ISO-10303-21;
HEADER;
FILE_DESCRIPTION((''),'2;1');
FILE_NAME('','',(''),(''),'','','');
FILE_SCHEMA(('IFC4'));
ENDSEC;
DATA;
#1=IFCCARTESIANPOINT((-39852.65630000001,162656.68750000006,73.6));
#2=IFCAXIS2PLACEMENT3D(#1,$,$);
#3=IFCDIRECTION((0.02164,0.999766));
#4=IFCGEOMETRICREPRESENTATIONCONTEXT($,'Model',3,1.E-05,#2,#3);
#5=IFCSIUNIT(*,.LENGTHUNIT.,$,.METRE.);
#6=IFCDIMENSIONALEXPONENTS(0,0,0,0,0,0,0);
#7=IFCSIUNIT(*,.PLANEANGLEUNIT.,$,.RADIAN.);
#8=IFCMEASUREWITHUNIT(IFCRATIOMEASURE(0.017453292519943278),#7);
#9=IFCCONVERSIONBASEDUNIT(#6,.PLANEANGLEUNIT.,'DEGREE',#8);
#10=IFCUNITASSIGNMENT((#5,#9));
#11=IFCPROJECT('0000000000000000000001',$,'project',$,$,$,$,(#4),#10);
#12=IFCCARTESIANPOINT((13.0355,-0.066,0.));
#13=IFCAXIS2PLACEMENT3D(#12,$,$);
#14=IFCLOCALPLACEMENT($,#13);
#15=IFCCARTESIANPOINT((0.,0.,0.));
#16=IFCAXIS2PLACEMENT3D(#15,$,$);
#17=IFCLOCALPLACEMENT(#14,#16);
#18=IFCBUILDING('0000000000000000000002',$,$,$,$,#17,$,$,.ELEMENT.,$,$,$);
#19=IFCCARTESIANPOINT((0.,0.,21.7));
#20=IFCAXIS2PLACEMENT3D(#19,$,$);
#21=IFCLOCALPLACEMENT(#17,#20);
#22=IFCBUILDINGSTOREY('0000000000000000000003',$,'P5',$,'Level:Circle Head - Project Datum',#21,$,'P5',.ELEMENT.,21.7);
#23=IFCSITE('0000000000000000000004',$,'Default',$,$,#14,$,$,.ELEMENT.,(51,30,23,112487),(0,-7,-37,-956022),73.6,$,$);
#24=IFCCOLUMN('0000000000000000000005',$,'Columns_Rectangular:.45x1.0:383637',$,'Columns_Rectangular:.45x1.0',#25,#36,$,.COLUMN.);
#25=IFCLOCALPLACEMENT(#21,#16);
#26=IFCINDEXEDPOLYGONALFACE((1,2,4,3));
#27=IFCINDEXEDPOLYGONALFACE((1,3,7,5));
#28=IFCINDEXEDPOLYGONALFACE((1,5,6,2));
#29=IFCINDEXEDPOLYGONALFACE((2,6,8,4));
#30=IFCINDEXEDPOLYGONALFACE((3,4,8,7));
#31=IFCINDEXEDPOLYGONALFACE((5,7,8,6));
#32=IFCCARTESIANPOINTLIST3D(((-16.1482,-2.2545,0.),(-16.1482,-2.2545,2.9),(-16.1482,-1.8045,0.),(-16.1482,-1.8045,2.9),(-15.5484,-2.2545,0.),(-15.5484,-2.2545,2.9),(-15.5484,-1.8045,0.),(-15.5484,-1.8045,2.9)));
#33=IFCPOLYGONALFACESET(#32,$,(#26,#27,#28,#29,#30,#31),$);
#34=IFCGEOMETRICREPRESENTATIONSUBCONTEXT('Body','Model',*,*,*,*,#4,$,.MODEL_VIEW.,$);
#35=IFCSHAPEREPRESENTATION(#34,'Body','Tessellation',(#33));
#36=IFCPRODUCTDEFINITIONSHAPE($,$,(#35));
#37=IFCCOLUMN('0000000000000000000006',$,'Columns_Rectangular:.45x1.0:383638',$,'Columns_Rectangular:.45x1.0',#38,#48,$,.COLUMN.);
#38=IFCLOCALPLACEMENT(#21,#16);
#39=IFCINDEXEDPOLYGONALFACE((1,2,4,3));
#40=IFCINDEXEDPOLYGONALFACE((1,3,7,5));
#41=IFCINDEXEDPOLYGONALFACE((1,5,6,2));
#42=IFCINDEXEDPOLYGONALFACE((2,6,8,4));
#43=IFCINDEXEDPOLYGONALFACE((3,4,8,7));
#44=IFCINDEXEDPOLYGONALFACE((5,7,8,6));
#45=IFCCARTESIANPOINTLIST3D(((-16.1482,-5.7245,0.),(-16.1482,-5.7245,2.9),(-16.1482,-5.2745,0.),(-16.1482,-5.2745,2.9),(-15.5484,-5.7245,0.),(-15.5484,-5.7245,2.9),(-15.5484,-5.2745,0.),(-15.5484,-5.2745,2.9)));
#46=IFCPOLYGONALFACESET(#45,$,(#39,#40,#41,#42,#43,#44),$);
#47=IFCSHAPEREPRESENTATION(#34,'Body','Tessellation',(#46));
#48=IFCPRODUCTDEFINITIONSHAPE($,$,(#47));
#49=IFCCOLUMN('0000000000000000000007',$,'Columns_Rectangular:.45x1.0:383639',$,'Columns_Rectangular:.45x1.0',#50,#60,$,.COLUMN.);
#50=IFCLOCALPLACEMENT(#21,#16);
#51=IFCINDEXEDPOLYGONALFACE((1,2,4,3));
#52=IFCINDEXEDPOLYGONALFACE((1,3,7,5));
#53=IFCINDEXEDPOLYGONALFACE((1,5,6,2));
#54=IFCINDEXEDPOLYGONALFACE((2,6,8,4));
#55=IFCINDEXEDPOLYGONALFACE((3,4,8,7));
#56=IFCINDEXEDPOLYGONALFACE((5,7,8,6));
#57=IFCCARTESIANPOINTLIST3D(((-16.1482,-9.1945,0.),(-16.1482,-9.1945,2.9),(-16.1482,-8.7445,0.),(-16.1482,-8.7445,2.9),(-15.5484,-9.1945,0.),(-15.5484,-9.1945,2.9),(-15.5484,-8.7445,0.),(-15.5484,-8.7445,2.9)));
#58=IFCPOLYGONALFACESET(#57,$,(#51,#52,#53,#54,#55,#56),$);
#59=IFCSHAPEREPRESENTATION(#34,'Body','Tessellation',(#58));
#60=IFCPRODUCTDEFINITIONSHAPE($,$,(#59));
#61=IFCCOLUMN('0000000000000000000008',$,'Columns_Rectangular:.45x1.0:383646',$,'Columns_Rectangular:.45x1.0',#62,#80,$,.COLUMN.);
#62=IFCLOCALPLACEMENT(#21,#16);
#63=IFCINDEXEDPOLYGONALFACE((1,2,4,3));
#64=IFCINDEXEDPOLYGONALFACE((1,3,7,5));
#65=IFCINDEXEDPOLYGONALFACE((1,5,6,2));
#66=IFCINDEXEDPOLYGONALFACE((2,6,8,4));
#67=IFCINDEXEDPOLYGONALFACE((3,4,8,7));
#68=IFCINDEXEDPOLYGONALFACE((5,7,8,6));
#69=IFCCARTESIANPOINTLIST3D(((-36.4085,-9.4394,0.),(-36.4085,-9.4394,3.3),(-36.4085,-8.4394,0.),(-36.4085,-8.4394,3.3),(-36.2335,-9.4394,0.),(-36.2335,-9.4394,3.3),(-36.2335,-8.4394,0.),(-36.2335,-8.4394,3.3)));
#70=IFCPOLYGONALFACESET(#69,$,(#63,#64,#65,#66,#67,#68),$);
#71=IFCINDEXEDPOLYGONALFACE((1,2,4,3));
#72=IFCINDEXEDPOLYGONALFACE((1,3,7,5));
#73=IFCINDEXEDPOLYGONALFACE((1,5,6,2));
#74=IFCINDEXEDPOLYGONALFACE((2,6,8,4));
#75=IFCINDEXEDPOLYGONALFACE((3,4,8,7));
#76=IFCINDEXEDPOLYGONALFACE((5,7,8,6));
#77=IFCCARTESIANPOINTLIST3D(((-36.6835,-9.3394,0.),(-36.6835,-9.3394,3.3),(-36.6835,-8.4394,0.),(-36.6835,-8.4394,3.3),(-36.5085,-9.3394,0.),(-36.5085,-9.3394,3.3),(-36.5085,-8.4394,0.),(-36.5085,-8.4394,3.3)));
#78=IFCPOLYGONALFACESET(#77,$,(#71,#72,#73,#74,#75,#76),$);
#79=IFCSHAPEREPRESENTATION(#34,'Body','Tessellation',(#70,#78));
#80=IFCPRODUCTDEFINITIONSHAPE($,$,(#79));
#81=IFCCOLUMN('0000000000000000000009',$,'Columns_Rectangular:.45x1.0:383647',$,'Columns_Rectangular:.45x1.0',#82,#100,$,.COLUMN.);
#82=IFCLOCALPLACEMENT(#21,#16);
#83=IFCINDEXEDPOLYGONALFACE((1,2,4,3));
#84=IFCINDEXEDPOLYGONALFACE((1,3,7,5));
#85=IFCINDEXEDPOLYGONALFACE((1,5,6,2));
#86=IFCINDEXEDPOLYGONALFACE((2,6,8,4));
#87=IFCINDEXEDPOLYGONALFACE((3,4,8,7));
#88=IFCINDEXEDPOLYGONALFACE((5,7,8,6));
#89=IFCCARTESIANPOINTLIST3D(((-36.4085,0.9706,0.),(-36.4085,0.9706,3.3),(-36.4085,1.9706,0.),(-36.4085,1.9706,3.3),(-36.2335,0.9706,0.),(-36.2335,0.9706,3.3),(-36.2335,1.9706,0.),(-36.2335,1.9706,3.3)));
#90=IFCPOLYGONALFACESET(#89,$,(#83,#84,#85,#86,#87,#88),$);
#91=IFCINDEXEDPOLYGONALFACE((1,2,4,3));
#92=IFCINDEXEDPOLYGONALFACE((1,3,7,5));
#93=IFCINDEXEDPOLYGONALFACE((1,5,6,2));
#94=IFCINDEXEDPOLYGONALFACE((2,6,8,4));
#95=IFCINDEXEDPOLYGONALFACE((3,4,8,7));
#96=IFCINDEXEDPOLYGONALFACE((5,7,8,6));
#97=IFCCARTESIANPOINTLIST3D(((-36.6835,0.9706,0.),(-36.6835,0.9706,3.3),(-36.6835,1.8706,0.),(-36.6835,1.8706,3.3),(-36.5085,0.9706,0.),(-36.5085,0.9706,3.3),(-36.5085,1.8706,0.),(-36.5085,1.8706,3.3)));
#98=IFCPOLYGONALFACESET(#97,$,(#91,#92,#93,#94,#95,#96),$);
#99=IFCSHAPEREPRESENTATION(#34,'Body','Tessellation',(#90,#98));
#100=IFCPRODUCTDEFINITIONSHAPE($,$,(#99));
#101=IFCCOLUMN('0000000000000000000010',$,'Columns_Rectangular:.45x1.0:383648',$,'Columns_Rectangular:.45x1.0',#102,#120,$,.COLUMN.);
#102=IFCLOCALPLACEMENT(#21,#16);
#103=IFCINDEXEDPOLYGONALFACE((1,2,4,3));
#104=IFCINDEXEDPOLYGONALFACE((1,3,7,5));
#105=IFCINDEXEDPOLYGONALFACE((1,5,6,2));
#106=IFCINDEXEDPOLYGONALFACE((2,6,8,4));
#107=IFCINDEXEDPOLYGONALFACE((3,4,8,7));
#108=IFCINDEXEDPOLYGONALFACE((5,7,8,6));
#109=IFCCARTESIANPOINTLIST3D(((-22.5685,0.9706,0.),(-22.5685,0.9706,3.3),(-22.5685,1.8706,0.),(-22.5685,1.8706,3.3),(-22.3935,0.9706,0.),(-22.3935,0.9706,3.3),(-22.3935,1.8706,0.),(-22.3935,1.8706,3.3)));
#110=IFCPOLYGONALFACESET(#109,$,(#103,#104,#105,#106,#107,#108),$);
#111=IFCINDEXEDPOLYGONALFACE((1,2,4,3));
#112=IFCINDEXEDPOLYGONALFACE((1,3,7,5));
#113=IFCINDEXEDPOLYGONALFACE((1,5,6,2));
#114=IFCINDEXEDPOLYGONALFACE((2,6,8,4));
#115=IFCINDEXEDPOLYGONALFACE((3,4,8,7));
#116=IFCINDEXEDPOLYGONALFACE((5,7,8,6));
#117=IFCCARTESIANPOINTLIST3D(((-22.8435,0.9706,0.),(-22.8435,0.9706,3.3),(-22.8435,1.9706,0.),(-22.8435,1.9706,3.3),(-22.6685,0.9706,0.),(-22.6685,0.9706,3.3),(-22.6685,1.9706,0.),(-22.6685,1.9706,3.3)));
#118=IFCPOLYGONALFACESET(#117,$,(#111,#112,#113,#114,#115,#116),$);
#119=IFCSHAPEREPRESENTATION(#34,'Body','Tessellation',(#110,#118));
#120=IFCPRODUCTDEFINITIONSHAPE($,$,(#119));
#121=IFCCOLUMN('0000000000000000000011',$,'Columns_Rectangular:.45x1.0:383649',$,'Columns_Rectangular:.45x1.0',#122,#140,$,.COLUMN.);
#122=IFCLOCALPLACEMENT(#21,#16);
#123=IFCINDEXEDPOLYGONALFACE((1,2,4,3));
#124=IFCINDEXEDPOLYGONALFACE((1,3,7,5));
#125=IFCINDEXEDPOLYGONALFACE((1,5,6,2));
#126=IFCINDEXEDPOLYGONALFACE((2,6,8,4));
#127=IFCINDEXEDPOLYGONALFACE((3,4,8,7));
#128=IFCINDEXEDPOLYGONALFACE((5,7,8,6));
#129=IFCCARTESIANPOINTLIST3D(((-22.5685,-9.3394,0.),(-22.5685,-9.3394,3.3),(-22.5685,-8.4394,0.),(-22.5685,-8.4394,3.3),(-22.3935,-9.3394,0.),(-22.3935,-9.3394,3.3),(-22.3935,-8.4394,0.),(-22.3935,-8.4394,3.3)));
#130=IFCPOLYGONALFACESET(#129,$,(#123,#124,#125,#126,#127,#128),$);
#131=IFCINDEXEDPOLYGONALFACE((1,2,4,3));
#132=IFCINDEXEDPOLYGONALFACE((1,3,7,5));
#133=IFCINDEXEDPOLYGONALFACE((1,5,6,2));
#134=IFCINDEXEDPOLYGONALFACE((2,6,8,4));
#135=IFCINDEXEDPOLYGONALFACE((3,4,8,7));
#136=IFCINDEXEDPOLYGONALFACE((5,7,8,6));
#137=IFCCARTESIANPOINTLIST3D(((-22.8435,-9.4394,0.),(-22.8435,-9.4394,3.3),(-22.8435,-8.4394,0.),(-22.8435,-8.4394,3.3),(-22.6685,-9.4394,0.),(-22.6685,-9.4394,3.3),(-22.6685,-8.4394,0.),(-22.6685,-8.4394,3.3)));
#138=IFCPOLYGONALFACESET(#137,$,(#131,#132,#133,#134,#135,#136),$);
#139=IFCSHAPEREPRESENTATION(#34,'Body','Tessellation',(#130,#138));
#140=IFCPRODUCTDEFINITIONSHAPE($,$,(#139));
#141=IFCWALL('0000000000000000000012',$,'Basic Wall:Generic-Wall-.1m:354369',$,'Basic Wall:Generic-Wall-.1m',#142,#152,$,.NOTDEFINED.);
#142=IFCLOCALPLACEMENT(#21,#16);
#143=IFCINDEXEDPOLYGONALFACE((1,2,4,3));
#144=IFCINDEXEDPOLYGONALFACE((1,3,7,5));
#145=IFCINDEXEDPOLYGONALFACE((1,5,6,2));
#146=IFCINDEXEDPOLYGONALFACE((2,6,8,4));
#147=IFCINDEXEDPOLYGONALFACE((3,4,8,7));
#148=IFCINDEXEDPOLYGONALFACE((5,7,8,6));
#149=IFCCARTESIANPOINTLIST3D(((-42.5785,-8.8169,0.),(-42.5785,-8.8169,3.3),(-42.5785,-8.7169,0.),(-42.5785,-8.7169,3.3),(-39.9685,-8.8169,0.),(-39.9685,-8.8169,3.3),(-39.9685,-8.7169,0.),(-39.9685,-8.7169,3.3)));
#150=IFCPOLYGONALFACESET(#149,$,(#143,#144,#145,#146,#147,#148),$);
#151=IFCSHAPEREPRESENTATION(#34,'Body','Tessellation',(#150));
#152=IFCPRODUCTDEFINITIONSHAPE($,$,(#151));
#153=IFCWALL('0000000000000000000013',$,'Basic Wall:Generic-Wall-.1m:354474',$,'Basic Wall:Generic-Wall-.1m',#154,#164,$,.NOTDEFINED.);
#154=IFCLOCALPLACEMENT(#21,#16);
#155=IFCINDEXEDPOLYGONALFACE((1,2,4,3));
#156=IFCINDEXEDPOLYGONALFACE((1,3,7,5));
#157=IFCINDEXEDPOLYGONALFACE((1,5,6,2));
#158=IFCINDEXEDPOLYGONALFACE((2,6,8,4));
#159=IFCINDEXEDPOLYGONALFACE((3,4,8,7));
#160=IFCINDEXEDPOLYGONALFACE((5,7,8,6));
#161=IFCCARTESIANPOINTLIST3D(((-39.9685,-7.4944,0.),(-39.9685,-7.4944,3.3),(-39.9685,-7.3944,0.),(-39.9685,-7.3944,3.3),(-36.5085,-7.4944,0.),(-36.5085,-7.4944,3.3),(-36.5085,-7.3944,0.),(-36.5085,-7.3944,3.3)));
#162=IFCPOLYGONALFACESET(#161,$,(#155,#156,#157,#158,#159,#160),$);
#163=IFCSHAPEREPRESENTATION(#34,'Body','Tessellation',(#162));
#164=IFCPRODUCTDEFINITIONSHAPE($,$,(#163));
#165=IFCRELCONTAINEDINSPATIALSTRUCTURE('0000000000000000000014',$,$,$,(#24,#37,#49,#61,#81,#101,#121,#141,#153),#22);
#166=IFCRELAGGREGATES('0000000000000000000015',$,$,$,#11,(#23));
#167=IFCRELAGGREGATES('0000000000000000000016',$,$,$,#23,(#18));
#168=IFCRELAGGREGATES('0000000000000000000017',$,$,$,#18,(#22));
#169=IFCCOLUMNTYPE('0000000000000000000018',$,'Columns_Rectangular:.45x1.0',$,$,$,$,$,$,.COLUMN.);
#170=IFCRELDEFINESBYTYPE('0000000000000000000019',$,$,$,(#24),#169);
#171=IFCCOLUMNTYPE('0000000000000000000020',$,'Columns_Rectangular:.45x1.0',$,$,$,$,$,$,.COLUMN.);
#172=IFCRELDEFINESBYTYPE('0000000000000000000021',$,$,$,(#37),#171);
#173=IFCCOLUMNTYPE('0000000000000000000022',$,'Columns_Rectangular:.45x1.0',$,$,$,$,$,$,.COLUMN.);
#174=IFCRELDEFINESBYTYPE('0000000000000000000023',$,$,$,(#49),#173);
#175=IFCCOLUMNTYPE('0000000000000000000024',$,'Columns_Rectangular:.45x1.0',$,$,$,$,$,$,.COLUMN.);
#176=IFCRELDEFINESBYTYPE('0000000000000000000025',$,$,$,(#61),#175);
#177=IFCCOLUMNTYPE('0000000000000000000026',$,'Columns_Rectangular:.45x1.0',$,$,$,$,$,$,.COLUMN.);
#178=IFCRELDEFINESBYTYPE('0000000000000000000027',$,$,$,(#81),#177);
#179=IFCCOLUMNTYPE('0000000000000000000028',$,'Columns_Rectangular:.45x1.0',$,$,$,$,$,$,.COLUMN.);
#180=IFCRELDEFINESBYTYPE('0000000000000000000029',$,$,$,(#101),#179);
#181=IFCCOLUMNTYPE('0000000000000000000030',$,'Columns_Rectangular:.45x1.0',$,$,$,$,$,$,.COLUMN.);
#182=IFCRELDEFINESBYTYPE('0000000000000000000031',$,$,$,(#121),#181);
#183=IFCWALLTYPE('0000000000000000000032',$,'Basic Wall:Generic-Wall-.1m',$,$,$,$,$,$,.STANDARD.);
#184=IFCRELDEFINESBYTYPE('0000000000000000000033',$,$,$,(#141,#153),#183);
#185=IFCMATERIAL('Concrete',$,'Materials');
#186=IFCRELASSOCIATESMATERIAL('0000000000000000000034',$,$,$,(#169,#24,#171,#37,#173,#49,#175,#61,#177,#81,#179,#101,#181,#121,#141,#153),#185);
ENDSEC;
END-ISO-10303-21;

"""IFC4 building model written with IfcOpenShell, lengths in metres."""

from ifc_helpers import new_model, entity, si_unit, converted_unit, direction, frame, origin, place, context, subcontext, project, spatial, indexed_curve, outline, extrude, source, transform, mapped, material, type_object, type_shapes, element, save


model = new_model("IFC4")

# Units and contexts
model_context = context("Model", 3, precision=1e-05, world=frame((-39852.65630000001, 162656.68750000006, 73.6)), true_north=direction((0.02164, 0.999766)))
body_context = subcontext(model_context, "Body", "Model", "MODEL_VIEW")
ifc_project = project(units=[si_unit("LENGTHUNIT", "METRE"), converted_unit("PLANEANGLEUNIT", "DEGREE", entity("IfcRatioMeasure", 0.017453292519943278), si_unit("PLANEANGLEUNIT", "RADIAN"), dimensions=[0, 0, 0, 0, 0, 0, 0])], contexts=[model_context])

# Site, building, storey
site_placement = place(None, frame((13.0355, -0.066, 0.0)))
site = spatial("IfcSite", under=ifc_project, at=site_placement, Name="Default", CompositionType="ELEMENT", RefLatitude=(51, 30, 23, 112487), RefLongitude=(0, -7, -37, -956022), RefElevation=73.6)
building_placement = place(site_placement, origin())
building = spatial("IfcBuilding", under=site, at=building_placement, CompositionType="ELEMENT")
storey_placement = place(building_placement, frame((0.0, 0.0, 21.7)))
storey = spatial("IfcBuildingStorey", under=building, at=storey_placement, Name="P5", ObjectType="Level:Circle Head - Project Datum", LongName="P5", CompositionType="ELEMENT", Elevation=21.7)

# Columns
ifc_material = material(Name="Concrete", Category="Materials")
column_type_1 = type_object("IfcColumnType", Name="Columns_Rectangular:.45x1.0", PredefinedType="COLUMN", material=ifc_material)
shared_shape_1 = source(origin(), body_context, "Body", "SweptSolid", [
    extrude(outline(indexed_curve([(-0.225, -0.2999), (0.225, -0.2999), (0.225, 0.2999), (-0.225, 0.2999), (-0.225, -0.2999)], self_intersect=False)), frame((-15.8483, -2.0295, 21.7), z_axis=(0.0, 0.0, 1.0), x_axis=(0.0, -1.0, 0.0)), (0.0, 0.0, 1.0), 2.9),
])
type_shapes(column_type_1, [shared_shape_1])
column_1_placement = place(storey_placement, frame((0.0, 0.0, -21.7)))
element("IfcColumn", 1, at=column_1_placement, inside=storey, type_object=column_type_1, material=ifc_material, Name="Columns_Rectangular:.45x1.0:383637", ObjectType="Columns_Rectangular:.45x1.0", PredefinedType="COLUMN", context=body_context, shape_type="MappedRepresentation", body=[
    mapped(shared_shape_1, transform((0.0, 0.0, 0.0), scale=1.0)),
])
column_type_2 = type_object("IfcColumnType", Name="Columns_Rectangular:.45x1.0", PredefinedType="COLUMN", material=ifc_material)
shared_shape_2 = source(origin(), body_context, "Body", "SweptSolid", [
    extrude(outline(indexed_curve([(-0.225, -0.2999), (0.225, -0.2999), (0.225, 0.2999), (-0.225, 0.2999), (-0.225, -0.2999)], self_intersect=False)), frame((-15.8483, -5.4995, 21.7), z_axis=(0.0, 0.0, 1.0), x_axis=(0.0, -1.0, 0.0)), (0.0, 0.0, 1.0), 2.9),
])
type_shapes(column_type_2, [shared_shape_2])
column_2_placement = place(storey_placement, frame((0.0, 0.0, -21.7)))
element("IfcColumn", 2, at=column_2_placement, inside=storey, type_object=column_type_2, material=ifc_material, Name="Columns_Rectangular:.45x1.0:383638", ObjectType="Columns_Rectangular:.45x1.0", PredefinedType="COLUMN", context=body_context, shape_type="MappedRepresentation", body=[
    mapped(shared_shape_2, transform((0.0, 0.0, 0.0), scale=1.0)),
])
column_type_3 = type_object("IfcColumnType", Name="Columns_Rectangular:.45x1.0", PredefinedType="COLUMN", material=ifc_material)
shared_shape_3 = source(origin(), body_context, "Body", "SweptSolid", [
    extrude(outline(indexed_curve([(-0.225, -0.2999), (0.225, -0.2999), (0.225, 0.2999), (-0.225, 0.2999), (-0.225, -0.2999)], self_intersect=False)), frame((-15.8483, -8.9695, 21.7), z_axis=(0.0, 0.0, 1.0), x_axis=(0.0, -1.0, 0.0)), (0.0, 0.0, 1.0), 2.9),
])
type_shapes(column_type_3, [shared_shape_3])
column_3_placement = place(storey_placement, frame((0.0, 0.0, -21.7)))
element("IfcColumn", 3, at=column_3_placement, inside=storey, type_object=column_type_3, material=ifc_material, Name="Columns_Rectangular:.45x1.0:383639", ObjectType="Columns_Rectangular:.45x1.0", PredefinedType="COLUMN", context=body_context, shape_type="MappedRepresentation", body=[
    mapped(shared_shape_3, transform((0.0, 0.0, 0.0), scale=1.0)),
])
column_type_4 = type_object("IfcColumnType", Name="Columns_Rectangular:.45x1.0", PredefinedType="COLUMN", material=ifc_material)
shared_shape_4 = source(origin(), body_context, "Body", "SweptSolid", [
    extrude(outline(indexed_curve([(-0.5, -0.0875), (0.5, -0.0875), (0.5, 0.0875), (-0.5, 0.0875), (-0.5, -0.0875)], self_intersect=False)), frame((-36.321, -8.9394, 21.7), z_axis=(0.0, 0.0, 1.0), x_axis=(0.0, -1.0, 0.0)), (0.0, 0.0, 1.0), 3.3),
    extrude(outline(indexed_curve([(-0.45, -0.0875), (0.45, -0.0875), (0.45, 0.0875), (-0.45, 0.0875), (-0.45, -0.0875)], self_intersect=False)), frame((-36.596, -8.8894, 21.7), z_axis=(0.0, 0.0, 1.0), x_axis=(0.0, -1.0, 0.0)), (0.0, 0.0, 1.0), 3.3),
])
type_shapes(column_type_4, [shared_shape_4])
column_4_placement = place(storey_placement, frame((0.0, 0.0, -21.7)))
element("IfcColumn", 4, at=column_4_placement, inside=storey, type_object=column_type_4, material=ifc_material, Name="Columns_Rectangular:.45x1.0:383646", ObjectType="Columns_Rectangular:.45x1.0", PredefinedType="COLUMN", context=body_context, shape_type="MappedRepresentation", body=[
    mapped(shared_shape_4, transform((0.0, 0.0, 0.0), scale=1.0)),
])
column_type_5 = type_object("IfcColumnType", Name="Columns_Rectangular:.45x1.0", PredefinedType="COLUMN", material=ifc_material)
shared_shape_5 = source(origin(), body_context, "Body", "SweptSolid", [
    extrude(outline(indexed_curve([(-0.5, -0.0875), (0.5, -0.0875), (0.5, 0.0875), (-0.5, 0.0875), (-0.5, -0.0875)], self_intersect=False)), frame((-36.321, 1.4706, 21.7), z_axis=(0.0, 0.0, 1.0), x_axis=(0.0, -1.0, 0.0)), (0.0, 0.0, 1.0), 3.3),
    extrude(outline(indexed_curve([(-0.45, -0.0875), (0.45, -0.0875), (0.45, 0.0875), (-0.45, 0.0875), (-0.45, -0.0875)], self_intersect=False)), frame((-36.596, 1.4206, 21.7), z_axis=(0.0, 0.0, 1.0), x_axis=(0.0, -1.0, 0.0)), (0.0, 0.0, 1.0), 3.3),
])
type_shapes(column_type_5, [shared_shape_5])
column_5_placement = place(storey_placement, frame((0.0, 0.0, -21.7)))
element("IfcColumn", 5, at=column_5_placement, inside=storey, type_object=column_type_5, material=ifc_material, Name="Columns_Rectangular:.45x1.0:383647", ObjectType="Columns_Rectangular:.45x1.0", PredefinedType="COLUMN", context=body_context, shape_type="MappedRepresentation", body=[
    mapped(shared_shape_5, transform((0.0, 0.0, 0.0), scale=1.0)),
])
column_type_6 = type_object("IfcColumnType", Name="Columns_Rectangular:.45x1.0", PredefinedType="COLUMN", material=ifc_material)
shared_shape_6 = source(origin(), body_context, "Body", "SweptSolid", [
    extrude(outline(indexed_curve([(-0.45, -0.0875), (0.45, -0.0875), (0.45, 0.0875), (-0.45, 0.0875), (-0.45, -0.0875)], self_intersect=False)), frame((-22.481, 1.4206, 21.7), z_axis=(0.0, 0.0, 1.0), x_axis=(0.0, -1.0, 0.0)), (0.0, 0.0, 1.0), 3.3),
    extrude(outline(indexed_curve([(-0.5, -0.0875), (0.5, -0.0875), (0.5, 0.0875), (-0.5, 0.0875), (-0.5, -0.0875)], self_intersect=False)), frame((-22.756, 1.4706, 21.7), z_axis=(0.0, 0.0, 1.0), x_axis=(0.0, -1.0, 0.0)), (0.0, 0.0, 1.0), 3.3),
])
type_shapes(column_type_6, [shared_shape_6])
column_6_placement = place(storey_placement, frame((0.0, 0.0, -21.7)))
element("IfcColumn", 6, at=column_6_placement, inside=storey, type_object=column_type_6, material=ifc_material, Name="Columns_Rectangular:.45x1.0:383648", ObjectType="Columns_Rectangular:.45x1.0", PredefinedType="COLUMN", context=body_context, shape_type="MappedRepresentation", body=[
    mapped(shared_shape_6, transform((0.0, 0.0, 0.0), scale=1.0)),
])
column_type_7 = type_object("IfcColumnType", Name="Columns_Rectangular:.45x1.0", PredefinedType="COLUMN", material=ifc_material)
shared_shape_7 = source(origin(), body_context, "Body", "SweptSolid", [
    extrude(outline(indexed_curve([(-0.45, -0.0875), (0.45, -0.0875), (0.45, 0.0875), (-0.45, 0.0875), (-0.45, -0.0875)], self_intersect=False)), frame((-22.481, -8.8894, 21.7), z_axis=(0.0, 0.0, 1.0), x_axis=(0.0, -1.0, 0.0)), (0.0, 0.0, 1.0), 3.3),
    extrude(outline(indexed_curve([(-0.5, -0.0875), (0.5, -0.0875), (0.5, 0.0875), (-0.5, 0.0875), (-0.5, -0.0875)], self_intersect=False)), frame((-22.756, -8.9394, 21.7), z_axis=(0.0, 0.0, 1.0), x_axis=(0.0, -1.0, 0.0)), (0.0, 0.0, 1.0), 3.3),
])
type_shapes(column_type_7, [shared_shape_7])
column_7_placement = place(storey_placement, frame((0.0, 0.0, -21.7)))
element("IfcColumn", 7, at=column_7_placement, inside=storey, type_object=column_type_7, material=ifc_material, Name="Columns_Rectangular:.45x1.0:383649", ObjectType="Columns_Rectangular:.45x1.0", PredefinedType="COLUMN", context=body_context, shape_type="MappedRepresentation", body=[
    mapped(shared_shape_7, transform((0.0, 0.0, 0.0), scale=1.0)),
])

# Walls
wall_type = type_object("IfcWallType", Name="Basic Wall:Generic-Wall-.1m", PredefinedType="STANDARD")
wall_1_placement = place(storey_placement, frame((-39.9685, -8.7669, 0.0), z_axis=(0.0, 0.0, 1.0), x_axis=(-1.0, 0.0, 0.0)))
element("IfcWall", 8, at=wall_1_placement, inside=storey, type_object=wall_type, material=ifc_material, Name="Basic Wall:Generic-Wall-.1m:354369", ObjectType="Basic Wall:Generic-Wall-.1m", PredefinedType="NOTDEFINED", context=body_context, shape_type="SweptSolid", body=[
    extrude(outline(indexed_curve([(2.61, 0.05), (0.0, 0.05), (0.0, -0.05), (2.61, -0.05), (2.61, 0.05)], self_intersect=False)), origin(), (0.0, 0.0, 1.0), 3.3),
])
wall_2_placement = place(storey_placement, frame((-36.5085, -7.4444, 0.0), z_axis=(0.0, 0.0, 1.0), x_axis=(-1.0, 0.0, 0.0)))
element("IfcWall", 9, at=wall_2_placement, inside=storey, type_object=wall_type, material=ifc_material, Name="Basic Wall:Generic-Wall-.1m:354474", ObjectType="Basic Wall:Generic-Wall-.1m", PredefinedType="NOTDEFINED", context=body_context, shape_type="SweptSolid", body=[
    extrude(outline(indexed_curve([(3.46, 0.05), (0.0, 0.05), (0.0, -0.05), (3.46, -0.05), (3.46, 0.05)], self_intersect=False)), origin(), (0.0, 0.0, 1.0), 3.3),
])

save(model, "model.ifc")
